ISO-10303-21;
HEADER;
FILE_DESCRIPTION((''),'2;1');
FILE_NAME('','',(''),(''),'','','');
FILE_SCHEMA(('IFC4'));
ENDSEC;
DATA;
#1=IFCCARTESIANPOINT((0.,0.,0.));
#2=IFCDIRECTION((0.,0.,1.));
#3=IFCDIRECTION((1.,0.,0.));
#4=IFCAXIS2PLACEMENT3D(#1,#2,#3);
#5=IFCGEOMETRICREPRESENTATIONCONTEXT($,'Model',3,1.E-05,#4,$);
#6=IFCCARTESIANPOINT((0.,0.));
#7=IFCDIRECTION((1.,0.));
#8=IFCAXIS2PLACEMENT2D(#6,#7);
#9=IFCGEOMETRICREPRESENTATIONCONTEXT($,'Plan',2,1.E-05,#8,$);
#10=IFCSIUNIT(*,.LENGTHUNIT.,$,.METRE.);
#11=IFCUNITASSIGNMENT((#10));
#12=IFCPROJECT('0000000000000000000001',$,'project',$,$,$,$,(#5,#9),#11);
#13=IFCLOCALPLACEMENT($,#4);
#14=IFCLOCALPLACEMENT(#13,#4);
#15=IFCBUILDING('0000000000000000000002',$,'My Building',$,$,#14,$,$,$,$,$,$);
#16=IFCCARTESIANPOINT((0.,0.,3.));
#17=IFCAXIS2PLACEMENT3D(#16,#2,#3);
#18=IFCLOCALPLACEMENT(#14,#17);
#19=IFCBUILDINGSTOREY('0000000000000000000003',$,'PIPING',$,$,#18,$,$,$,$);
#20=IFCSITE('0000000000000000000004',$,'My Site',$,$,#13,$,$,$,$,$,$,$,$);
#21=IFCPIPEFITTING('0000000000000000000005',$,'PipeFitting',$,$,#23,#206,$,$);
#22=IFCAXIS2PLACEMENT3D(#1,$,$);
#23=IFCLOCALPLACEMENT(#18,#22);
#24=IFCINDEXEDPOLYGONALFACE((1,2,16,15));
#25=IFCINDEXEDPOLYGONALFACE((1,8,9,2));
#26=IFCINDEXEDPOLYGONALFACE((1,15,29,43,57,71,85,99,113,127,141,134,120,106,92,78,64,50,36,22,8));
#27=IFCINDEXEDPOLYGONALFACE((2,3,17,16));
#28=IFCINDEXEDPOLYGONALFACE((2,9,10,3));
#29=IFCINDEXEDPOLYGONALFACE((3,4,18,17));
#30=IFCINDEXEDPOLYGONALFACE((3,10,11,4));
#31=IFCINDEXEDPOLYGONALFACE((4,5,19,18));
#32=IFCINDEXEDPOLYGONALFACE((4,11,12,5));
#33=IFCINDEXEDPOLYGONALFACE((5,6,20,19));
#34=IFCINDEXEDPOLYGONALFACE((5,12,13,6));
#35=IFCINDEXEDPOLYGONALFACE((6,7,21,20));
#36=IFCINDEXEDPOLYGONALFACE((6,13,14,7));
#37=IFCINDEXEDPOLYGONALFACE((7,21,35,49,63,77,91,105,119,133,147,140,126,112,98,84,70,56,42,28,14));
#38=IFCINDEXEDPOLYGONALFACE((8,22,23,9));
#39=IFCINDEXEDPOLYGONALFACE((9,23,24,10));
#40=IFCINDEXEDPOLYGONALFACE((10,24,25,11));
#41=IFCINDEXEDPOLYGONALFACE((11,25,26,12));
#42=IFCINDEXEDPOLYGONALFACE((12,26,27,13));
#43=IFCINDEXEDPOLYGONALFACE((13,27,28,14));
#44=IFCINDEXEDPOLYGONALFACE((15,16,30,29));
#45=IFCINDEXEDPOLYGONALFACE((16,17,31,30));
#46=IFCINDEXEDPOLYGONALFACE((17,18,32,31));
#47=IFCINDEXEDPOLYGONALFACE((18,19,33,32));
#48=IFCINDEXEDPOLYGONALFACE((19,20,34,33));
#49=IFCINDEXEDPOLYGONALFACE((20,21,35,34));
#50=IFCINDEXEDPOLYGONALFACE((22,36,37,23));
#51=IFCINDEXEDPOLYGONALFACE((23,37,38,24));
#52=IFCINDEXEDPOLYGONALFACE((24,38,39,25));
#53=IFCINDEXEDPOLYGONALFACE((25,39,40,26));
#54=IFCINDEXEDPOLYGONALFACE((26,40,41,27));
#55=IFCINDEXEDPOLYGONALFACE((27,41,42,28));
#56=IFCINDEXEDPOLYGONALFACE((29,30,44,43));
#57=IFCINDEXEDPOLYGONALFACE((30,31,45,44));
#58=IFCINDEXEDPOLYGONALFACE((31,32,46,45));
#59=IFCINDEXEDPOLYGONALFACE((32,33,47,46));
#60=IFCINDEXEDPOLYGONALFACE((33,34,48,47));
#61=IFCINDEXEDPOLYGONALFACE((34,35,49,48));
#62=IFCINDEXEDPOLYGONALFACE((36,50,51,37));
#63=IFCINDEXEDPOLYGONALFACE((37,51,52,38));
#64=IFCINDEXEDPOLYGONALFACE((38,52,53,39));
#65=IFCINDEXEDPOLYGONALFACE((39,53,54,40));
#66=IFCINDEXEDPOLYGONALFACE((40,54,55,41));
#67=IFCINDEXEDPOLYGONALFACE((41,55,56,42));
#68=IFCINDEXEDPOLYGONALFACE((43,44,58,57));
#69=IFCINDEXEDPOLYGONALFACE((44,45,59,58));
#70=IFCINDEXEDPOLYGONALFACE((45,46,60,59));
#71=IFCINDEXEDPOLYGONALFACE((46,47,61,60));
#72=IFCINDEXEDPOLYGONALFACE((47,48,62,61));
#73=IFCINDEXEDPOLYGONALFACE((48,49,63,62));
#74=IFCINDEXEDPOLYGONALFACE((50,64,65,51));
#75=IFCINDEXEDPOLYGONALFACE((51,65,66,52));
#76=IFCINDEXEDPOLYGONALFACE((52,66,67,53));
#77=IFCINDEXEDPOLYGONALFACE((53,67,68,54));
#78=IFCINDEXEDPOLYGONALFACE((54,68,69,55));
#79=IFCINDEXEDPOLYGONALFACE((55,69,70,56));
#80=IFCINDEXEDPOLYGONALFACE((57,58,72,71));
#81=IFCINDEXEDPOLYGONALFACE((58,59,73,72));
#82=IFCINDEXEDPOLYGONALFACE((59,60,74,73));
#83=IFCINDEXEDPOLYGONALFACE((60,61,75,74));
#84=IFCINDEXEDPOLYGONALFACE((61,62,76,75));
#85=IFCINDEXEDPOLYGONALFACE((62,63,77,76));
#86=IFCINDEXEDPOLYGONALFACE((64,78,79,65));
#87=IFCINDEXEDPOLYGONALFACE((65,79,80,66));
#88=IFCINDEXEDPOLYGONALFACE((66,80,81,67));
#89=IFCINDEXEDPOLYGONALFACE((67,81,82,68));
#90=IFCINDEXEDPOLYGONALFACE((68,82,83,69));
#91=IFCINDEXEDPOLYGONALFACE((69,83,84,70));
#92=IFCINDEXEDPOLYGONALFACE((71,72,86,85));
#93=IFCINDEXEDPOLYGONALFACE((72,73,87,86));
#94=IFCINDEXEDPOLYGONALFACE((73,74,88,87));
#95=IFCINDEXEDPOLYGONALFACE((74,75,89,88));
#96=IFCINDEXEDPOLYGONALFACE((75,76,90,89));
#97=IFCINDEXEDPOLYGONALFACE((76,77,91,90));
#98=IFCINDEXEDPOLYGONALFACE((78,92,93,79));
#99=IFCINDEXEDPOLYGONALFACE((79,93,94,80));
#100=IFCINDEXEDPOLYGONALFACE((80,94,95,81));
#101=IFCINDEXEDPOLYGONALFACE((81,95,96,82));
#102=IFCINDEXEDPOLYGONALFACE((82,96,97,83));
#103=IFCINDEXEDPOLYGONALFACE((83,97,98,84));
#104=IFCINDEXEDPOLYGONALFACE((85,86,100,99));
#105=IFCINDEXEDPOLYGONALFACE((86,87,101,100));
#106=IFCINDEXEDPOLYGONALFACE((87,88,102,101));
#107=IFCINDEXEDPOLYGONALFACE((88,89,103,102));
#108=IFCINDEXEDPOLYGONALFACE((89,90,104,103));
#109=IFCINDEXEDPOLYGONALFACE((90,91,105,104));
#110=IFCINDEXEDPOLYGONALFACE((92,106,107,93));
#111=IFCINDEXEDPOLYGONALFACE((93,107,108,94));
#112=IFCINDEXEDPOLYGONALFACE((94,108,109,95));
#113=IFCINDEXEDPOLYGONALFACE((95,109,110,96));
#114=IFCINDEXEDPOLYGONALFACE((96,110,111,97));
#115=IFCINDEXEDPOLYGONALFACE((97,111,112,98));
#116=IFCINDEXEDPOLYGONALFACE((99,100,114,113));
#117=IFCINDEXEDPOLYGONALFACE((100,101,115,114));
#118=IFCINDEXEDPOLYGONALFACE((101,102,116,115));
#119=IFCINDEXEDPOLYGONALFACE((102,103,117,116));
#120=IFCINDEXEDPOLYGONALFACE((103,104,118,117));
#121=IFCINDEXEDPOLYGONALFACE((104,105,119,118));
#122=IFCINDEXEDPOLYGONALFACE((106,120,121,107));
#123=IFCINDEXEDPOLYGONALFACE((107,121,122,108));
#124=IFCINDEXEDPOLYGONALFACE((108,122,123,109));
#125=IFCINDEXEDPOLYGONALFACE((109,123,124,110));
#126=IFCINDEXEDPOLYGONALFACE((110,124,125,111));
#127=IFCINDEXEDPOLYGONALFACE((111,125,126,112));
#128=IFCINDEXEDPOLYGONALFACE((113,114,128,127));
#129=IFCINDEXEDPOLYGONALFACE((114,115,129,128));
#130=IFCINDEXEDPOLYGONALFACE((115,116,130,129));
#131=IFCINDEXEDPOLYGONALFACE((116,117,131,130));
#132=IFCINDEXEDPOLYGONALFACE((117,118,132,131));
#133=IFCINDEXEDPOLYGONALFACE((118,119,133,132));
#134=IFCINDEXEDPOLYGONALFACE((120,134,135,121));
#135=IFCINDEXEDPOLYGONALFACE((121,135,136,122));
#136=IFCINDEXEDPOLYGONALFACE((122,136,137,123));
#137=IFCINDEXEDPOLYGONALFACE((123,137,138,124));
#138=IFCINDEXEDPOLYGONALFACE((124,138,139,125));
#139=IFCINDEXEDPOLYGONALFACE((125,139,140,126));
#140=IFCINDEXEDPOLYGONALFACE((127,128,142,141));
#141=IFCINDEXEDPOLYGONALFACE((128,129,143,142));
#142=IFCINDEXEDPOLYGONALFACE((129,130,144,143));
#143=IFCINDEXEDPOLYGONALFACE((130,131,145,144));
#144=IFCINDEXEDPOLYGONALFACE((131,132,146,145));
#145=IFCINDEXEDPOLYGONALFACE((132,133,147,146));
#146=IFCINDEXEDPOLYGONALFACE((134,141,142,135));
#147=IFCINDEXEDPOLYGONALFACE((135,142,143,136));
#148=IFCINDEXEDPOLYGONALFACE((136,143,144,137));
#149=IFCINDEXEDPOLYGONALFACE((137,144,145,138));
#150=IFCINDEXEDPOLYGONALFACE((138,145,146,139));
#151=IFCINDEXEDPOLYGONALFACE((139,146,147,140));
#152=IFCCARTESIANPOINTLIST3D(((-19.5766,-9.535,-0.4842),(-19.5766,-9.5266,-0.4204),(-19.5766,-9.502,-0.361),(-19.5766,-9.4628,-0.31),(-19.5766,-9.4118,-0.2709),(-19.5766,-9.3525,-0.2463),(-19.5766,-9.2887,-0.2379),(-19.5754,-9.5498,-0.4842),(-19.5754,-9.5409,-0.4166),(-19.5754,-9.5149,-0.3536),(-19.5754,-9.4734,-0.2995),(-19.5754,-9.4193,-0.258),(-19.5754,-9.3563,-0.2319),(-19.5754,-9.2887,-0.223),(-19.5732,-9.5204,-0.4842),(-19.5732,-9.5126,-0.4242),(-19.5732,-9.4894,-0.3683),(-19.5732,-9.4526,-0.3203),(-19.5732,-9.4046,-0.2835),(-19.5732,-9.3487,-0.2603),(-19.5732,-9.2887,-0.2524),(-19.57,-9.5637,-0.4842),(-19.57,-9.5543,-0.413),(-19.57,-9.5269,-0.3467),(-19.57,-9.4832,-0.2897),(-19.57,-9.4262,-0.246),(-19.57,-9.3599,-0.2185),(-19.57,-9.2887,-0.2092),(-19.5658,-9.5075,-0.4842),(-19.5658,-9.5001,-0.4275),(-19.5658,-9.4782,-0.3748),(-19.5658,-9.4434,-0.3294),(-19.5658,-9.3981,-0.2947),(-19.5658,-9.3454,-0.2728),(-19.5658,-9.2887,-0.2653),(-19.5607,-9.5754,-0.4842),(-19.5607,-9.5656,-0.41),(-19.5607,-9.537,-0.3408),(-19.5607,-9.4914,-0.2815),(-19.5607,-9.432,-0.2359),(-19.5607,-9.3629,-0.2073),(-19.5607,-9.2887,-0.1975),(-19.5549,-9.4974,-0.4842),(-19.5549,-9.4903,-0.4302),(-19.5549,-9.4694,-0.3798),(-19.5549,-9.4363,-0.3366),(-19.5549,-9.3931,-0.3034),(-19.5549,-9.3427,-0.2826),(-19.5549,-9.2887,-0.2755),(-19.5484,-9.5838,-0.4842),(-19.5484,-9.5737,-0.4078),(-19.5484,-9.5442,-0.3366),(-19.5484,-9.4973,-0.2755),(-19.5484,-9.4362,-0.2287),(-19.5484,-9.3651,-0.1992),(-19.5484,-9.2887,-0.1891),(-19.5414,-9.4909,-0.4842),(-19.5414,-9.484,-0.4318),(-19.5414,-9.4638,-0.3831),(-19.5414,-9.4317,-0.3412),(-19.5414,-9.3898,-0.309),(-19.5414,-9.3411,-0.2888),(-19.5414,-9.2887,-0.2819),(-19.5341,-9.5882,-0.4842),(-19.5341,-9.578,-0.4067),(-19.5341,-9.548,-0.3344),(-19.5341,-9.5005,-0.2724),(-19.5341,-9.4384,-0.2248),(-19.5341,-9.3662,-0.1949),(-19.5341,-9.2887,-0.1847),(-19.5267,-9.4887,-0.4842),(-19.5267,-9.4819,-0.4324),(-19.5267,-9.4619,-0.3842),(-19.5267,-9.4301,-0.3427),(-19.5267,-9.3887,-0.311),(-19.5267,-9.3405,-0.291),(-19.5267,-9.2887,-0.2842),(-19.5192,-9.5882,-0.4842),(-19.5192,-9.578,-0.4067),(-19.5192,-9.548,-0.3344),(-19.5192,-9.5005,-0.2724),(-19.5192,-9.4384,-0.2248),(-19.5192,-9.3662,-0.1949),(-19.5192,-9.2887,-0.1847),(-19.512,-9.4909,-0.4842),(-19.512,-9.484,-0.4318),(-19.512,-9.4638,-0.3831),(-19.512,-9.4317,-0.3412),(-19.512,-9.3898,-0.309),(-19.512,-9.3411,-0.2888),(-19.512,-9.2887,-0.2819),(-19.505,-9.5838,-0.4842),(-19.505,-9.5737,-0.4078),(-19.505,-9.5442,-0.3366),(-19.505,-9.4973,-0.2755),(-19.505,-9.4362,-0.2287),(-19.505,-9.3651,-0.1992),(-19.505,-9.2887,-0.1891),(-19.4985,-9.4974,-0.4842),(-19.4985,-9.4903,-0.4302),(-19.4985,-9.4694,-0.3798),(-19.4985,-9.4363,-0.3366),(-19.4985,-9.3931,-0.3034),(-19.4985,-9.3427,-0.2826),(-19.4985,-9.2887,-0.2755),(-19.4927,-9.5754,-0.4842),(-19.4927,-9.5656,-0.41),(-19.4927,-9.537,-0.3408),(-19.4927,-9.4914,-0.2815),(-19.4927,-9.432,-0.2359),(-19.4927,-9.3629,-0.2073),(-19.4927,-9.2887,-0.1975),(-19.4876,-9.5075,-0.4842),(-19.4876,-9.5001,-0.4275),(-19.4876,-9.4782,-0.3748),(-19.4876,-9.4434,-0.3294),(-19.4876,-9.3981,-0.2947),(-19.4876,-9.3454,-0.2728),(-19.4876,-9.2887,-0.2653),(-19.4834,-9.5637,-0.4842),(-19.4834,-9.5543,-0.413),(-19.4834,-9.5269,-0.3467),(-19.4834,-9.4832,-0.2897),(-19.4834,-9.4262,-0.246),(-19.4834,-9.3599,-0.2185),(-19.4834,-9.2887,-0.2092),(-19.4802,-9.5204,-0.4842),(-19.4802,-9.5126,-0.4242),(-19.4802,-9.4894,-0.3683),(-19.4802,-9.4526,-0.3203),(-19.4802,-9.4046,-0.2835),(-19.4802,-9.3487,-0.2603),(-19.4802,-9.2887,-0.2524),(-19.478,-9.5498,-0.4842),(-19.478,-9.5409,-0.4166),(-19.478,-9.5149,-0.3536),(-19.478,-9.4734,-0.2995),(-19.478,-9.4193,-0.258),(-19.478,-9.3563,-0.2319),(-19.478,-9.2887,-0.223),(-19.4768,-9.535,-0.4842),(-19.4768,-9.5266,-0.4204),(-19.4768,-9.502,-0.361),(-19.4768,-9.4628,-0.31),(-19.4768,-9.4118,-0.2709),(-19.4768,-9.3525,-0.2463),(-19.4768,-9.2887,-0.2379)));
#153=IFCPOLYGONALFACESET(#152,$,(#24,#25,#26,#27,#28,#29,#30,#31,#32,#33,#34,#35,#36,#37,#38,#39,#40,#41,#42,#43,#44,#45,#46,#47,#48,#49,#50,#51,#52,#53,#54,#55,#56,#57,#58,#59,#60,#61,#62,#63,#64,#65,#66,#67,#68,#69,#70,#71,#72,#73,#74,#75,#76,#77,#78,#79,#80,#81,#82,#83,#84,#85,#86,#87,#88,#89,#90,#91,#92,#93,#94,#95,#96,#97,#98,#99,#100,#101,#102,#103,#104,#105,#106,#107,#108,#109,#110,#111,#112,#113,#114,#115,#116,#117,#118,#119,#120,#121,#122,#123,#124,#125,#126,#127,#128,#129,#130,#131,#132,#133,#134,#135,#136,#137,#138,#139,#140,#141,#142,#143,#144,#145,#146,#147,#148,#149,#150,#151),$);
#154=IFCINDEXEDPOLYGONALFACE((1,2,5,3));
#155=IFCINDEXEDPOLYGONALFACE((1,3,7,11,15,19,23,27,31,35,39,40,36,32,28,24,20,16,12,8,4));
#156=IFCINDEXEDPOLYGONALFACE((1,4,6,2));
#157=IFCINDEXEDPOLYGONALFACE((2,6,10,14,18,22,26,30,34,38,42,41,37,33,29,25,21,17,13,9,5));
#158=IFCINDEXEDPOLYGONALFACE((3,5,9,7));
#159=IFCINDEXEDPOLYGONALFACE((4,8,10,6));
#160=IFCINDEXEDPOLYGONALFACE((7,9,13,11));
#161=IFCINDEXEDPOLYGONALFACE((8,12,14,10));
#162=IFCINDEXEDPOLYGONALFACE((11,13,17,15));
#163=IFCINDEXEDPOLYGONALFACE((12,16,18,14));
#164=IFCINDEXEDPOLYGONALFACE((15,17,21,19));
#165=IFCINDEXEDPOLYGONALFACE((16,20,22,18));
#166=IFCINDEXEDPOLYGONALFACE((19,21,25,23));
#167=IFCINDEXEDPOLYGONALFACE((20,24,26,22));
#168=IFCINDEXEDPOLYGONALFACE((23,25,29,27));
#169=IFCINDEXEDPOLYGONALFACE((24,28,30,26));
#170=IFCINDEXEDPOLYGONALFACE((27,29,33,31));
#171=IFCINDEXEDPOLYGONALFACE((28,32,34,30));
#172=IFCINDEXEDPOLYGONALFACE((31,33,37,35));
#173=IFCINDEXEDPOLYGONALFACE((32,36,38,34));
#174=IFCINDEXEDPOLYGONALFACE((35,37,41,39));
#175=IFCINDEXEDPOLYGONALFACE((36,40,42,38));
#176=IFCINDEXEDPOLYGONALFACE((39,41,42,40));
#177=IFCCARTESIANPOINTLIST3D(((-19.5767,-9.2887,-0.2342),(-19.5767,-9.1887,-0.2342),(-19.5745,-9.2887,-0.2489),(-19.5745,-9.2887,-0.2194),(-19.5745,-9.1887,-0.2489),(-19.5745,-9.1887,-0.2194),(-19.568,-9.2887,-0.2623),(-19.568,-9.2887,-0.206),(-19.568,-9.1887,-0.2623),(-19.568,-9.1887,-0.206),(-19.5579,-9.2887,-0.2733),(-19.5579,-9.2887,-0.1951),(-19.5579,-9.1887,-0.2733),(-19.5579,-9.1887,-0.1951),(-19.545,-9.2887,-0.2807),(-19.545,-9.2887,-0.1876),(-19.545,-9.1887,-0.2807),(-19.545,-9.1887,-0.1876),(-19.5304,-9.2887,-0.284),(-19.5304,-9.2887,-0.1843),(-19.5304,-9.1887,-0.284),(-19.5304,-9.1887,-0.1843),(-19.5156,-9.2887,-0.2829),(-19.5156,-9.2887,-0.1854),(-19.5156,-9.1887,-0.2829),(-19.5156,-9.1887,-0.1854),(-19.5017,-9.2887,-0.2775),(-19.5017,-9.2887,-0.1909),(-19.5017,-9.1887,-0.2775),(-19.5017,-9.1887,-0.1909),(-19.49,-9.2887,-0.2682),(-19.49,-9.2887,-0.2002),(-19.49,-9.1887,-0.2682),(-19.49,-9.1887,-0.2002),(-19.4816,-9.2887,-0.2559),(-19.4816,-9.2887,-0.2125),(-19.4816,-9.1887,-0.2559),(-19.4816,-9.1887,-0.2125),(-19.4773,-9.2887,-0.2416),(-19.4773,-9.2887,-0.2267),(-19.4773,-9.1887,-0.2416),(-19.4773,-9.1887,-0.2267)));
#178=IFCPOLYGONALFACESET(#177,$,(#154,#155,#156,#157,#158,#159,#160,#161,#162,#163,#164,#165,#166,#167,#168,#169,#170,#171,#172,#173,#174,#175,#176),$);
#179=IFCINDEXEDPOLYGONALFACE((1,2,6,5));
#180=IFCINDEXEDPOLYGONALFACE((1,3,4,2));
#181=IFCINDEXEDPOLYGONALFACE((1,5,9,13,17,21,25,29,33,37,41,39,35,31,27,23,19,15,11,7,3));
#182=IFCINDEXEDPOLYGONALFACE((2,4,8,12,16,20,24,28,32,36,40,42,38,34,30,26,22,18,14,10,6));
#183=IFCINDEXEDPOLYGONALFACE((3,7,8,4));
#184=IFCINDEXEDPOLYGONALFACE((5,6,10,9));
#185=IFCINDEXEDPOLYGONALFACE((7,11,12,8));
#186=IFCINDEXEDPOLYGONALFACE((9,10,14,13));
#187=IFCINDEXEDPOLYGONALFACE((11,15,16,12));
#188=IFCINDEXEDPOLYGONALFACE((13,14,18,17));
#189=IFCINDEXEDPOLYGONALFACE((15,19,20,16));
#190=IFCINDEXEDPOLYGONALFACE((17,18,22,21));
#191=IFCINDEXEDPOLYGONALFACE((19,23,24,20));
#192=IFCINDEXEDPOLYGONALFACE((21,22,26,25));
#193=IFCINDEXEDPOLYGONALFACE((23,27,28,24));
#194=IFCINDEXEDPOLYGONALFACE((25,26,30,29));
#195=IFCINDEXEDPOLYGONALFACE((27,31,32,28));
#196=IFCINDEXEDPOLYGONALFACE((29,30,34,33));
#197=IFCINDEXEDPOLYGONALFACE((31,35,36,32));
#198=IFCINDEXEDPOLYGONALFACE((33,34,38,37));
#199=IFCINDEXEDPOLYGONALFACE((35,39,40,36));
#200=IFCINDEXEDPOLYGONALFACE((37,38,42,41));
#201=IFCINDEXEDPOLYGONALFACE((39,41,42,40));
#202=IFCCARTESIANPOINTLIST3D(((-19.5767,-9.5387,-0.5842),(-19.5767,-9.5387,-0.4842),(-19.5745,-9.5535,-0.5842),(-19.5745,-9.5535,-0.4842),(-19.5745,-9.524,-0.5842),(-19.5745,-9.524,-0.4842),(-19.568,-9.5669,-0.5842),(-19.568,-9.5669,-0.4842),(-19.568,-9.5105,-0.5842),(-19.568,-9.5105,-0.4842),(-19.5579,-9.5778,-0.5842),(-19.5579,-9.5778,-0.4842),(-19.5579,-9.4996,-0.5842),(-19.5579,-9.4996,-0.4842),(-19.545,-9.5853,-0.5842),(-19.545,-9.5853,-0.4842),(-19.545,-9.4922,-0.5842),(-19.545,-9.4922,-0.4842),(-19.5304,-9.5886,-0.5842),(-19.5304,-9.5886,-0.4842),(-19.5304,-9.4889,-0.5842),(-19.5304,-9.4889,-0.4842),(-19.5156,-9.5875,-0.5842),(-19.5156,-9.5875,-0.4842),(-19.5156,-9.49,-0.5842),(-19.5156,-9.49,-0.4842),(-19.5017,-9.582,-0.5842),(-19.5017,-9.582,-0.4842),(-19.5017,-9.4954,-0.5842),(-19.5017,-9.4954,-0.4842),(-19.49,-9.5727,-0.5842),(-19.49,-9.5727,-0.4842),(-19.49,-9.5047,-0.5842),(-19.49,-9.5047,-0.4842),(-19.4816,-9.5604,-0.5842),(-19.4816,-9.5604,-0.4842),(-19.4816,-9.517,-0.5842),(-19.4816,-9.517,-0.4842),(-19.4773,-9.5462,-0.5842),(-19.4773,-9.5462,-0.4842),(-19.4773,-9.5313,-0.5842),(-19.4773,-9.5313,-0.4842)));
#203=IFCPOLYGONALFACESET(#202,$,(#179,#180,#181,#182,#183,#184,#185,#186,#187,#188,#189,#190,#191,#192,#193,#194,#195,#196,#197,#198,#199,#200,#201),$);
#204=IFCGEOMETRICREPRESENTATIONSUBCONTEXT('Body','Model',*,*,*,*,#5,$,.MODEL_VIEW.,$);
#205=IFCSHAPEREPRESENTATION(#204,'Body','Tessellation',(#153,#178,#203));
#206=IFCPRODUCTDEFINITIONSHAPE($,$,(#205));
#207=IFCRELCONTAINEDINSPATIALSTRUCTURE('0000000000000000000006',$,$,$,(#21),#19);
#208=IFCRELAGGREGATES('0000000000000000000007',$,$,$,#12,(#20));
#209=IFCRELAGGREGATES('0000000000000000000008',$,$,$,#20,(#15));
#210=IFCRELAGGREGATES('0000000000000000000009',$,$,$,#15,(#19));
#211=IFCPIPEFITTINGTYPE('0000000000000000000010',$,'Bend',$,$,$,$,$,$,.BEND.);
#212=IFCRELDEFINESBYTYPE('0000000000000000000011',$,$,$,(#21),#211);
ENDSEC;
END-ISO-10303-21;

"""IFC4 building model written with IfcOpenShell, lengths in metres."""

from ifc_helpers import new_model, entity, si_unit, frame, origin_with_axes, origin_2d_with_axis, place, context, subcontext, project, spatial, circle, extrude, source, transform, mapped, type_object, type_shapes, element, save


model = new_model("IFC4")

# Units and contexts
model_context = context("Model", 3, precision=1e-05, world=origin_with_axes())
plan_context = context("Plan", 2, precision=1e-05, world=origin_2d_with_axis())
body_context = subcontext(model_context, "Body", "Model", "MODEL_VIEW")
ifc_project = project(units=[si_unit("LENGTHUNIT", "METRE")], contexts=[model_context, plan_context])

# Site, building, storey
site_placement = place(None, origin_with_axes())
site = spatial("IfcSite", under=ifc_project, at=site_placement, Name="My Site")
building_placement = place(site_placement, origin_with_axes())
building = spatial("IfcBuilding", under=site, at=building_placement, Name="My Building")
storey_placement = place(building_placement, frame((0.0, 0.0, 3.0), z_axis=(0.0, 0.0, 1.0), x_axis=(1.0, 0.0, 0.0)))
storey = spatial("IfcBuildingStorey", under=building, at=storey_placement, Name="PIPING")

# Pipe fitting
pipe_fitting_type = type_object("IfcPipeFittingType", Name="Bend", PredefinedType="BEND")
shared_shape = source(origin_with_axes(), body_context, "Body", "SolidModel", [
    entity("IfcSweptDiskSolid", entity("IfcIndexedPolyCurve", entity("IfcCartesianPointList3D", [[0.0, 0.0, -0.1], [0.0, -0.0732, -0.2768], [0.0, -0.25, -0.35]]), [entity("IfcArcIndex", [1, 2, 3])]), 0.05),
    extrude(circle(Radius=0.05), origin_with_axes(), (0.0, 0.0, -1.0), 0.1),
    extrude(circle(Radius=0.05), frame((0.0, -0.25, -0.35), z_axis=(0.0, -1.0, 0.0), x_axis=(1.0, 0.0, 0.0)), (0.0, 0.0, 1.0), 0.1),
])
type_shapes(pipe_fitting_type, [shared_shape])
for number, where, z_axis, x_axis, name in (
    (1, (-19.5267, -9.1887, -0.2342), (0.0, 1.0, 0.0), (-1.0, 0.0, 0.0), "PipeFitting"),
):
    element("IfcPipeFitting", number, at=place(storey_placement, frame(where, z_axis=z_axis, x_axis=x_axis)), inside=storey, type_object=pipe_fitting_type, Name=name, context=body_context, shape_type="MappedRepresentation", body=[
        mapped(shared_shape, transform((0.0, 0.0, 0.0), x_axis=(1.0, 0.0, 0.0), y_axis=(0.0, 1.0, 0.0), z_axis=(0.0, 0.0, 1.0), scale=1.0)),
    ])

save(model, "model.ifc")
